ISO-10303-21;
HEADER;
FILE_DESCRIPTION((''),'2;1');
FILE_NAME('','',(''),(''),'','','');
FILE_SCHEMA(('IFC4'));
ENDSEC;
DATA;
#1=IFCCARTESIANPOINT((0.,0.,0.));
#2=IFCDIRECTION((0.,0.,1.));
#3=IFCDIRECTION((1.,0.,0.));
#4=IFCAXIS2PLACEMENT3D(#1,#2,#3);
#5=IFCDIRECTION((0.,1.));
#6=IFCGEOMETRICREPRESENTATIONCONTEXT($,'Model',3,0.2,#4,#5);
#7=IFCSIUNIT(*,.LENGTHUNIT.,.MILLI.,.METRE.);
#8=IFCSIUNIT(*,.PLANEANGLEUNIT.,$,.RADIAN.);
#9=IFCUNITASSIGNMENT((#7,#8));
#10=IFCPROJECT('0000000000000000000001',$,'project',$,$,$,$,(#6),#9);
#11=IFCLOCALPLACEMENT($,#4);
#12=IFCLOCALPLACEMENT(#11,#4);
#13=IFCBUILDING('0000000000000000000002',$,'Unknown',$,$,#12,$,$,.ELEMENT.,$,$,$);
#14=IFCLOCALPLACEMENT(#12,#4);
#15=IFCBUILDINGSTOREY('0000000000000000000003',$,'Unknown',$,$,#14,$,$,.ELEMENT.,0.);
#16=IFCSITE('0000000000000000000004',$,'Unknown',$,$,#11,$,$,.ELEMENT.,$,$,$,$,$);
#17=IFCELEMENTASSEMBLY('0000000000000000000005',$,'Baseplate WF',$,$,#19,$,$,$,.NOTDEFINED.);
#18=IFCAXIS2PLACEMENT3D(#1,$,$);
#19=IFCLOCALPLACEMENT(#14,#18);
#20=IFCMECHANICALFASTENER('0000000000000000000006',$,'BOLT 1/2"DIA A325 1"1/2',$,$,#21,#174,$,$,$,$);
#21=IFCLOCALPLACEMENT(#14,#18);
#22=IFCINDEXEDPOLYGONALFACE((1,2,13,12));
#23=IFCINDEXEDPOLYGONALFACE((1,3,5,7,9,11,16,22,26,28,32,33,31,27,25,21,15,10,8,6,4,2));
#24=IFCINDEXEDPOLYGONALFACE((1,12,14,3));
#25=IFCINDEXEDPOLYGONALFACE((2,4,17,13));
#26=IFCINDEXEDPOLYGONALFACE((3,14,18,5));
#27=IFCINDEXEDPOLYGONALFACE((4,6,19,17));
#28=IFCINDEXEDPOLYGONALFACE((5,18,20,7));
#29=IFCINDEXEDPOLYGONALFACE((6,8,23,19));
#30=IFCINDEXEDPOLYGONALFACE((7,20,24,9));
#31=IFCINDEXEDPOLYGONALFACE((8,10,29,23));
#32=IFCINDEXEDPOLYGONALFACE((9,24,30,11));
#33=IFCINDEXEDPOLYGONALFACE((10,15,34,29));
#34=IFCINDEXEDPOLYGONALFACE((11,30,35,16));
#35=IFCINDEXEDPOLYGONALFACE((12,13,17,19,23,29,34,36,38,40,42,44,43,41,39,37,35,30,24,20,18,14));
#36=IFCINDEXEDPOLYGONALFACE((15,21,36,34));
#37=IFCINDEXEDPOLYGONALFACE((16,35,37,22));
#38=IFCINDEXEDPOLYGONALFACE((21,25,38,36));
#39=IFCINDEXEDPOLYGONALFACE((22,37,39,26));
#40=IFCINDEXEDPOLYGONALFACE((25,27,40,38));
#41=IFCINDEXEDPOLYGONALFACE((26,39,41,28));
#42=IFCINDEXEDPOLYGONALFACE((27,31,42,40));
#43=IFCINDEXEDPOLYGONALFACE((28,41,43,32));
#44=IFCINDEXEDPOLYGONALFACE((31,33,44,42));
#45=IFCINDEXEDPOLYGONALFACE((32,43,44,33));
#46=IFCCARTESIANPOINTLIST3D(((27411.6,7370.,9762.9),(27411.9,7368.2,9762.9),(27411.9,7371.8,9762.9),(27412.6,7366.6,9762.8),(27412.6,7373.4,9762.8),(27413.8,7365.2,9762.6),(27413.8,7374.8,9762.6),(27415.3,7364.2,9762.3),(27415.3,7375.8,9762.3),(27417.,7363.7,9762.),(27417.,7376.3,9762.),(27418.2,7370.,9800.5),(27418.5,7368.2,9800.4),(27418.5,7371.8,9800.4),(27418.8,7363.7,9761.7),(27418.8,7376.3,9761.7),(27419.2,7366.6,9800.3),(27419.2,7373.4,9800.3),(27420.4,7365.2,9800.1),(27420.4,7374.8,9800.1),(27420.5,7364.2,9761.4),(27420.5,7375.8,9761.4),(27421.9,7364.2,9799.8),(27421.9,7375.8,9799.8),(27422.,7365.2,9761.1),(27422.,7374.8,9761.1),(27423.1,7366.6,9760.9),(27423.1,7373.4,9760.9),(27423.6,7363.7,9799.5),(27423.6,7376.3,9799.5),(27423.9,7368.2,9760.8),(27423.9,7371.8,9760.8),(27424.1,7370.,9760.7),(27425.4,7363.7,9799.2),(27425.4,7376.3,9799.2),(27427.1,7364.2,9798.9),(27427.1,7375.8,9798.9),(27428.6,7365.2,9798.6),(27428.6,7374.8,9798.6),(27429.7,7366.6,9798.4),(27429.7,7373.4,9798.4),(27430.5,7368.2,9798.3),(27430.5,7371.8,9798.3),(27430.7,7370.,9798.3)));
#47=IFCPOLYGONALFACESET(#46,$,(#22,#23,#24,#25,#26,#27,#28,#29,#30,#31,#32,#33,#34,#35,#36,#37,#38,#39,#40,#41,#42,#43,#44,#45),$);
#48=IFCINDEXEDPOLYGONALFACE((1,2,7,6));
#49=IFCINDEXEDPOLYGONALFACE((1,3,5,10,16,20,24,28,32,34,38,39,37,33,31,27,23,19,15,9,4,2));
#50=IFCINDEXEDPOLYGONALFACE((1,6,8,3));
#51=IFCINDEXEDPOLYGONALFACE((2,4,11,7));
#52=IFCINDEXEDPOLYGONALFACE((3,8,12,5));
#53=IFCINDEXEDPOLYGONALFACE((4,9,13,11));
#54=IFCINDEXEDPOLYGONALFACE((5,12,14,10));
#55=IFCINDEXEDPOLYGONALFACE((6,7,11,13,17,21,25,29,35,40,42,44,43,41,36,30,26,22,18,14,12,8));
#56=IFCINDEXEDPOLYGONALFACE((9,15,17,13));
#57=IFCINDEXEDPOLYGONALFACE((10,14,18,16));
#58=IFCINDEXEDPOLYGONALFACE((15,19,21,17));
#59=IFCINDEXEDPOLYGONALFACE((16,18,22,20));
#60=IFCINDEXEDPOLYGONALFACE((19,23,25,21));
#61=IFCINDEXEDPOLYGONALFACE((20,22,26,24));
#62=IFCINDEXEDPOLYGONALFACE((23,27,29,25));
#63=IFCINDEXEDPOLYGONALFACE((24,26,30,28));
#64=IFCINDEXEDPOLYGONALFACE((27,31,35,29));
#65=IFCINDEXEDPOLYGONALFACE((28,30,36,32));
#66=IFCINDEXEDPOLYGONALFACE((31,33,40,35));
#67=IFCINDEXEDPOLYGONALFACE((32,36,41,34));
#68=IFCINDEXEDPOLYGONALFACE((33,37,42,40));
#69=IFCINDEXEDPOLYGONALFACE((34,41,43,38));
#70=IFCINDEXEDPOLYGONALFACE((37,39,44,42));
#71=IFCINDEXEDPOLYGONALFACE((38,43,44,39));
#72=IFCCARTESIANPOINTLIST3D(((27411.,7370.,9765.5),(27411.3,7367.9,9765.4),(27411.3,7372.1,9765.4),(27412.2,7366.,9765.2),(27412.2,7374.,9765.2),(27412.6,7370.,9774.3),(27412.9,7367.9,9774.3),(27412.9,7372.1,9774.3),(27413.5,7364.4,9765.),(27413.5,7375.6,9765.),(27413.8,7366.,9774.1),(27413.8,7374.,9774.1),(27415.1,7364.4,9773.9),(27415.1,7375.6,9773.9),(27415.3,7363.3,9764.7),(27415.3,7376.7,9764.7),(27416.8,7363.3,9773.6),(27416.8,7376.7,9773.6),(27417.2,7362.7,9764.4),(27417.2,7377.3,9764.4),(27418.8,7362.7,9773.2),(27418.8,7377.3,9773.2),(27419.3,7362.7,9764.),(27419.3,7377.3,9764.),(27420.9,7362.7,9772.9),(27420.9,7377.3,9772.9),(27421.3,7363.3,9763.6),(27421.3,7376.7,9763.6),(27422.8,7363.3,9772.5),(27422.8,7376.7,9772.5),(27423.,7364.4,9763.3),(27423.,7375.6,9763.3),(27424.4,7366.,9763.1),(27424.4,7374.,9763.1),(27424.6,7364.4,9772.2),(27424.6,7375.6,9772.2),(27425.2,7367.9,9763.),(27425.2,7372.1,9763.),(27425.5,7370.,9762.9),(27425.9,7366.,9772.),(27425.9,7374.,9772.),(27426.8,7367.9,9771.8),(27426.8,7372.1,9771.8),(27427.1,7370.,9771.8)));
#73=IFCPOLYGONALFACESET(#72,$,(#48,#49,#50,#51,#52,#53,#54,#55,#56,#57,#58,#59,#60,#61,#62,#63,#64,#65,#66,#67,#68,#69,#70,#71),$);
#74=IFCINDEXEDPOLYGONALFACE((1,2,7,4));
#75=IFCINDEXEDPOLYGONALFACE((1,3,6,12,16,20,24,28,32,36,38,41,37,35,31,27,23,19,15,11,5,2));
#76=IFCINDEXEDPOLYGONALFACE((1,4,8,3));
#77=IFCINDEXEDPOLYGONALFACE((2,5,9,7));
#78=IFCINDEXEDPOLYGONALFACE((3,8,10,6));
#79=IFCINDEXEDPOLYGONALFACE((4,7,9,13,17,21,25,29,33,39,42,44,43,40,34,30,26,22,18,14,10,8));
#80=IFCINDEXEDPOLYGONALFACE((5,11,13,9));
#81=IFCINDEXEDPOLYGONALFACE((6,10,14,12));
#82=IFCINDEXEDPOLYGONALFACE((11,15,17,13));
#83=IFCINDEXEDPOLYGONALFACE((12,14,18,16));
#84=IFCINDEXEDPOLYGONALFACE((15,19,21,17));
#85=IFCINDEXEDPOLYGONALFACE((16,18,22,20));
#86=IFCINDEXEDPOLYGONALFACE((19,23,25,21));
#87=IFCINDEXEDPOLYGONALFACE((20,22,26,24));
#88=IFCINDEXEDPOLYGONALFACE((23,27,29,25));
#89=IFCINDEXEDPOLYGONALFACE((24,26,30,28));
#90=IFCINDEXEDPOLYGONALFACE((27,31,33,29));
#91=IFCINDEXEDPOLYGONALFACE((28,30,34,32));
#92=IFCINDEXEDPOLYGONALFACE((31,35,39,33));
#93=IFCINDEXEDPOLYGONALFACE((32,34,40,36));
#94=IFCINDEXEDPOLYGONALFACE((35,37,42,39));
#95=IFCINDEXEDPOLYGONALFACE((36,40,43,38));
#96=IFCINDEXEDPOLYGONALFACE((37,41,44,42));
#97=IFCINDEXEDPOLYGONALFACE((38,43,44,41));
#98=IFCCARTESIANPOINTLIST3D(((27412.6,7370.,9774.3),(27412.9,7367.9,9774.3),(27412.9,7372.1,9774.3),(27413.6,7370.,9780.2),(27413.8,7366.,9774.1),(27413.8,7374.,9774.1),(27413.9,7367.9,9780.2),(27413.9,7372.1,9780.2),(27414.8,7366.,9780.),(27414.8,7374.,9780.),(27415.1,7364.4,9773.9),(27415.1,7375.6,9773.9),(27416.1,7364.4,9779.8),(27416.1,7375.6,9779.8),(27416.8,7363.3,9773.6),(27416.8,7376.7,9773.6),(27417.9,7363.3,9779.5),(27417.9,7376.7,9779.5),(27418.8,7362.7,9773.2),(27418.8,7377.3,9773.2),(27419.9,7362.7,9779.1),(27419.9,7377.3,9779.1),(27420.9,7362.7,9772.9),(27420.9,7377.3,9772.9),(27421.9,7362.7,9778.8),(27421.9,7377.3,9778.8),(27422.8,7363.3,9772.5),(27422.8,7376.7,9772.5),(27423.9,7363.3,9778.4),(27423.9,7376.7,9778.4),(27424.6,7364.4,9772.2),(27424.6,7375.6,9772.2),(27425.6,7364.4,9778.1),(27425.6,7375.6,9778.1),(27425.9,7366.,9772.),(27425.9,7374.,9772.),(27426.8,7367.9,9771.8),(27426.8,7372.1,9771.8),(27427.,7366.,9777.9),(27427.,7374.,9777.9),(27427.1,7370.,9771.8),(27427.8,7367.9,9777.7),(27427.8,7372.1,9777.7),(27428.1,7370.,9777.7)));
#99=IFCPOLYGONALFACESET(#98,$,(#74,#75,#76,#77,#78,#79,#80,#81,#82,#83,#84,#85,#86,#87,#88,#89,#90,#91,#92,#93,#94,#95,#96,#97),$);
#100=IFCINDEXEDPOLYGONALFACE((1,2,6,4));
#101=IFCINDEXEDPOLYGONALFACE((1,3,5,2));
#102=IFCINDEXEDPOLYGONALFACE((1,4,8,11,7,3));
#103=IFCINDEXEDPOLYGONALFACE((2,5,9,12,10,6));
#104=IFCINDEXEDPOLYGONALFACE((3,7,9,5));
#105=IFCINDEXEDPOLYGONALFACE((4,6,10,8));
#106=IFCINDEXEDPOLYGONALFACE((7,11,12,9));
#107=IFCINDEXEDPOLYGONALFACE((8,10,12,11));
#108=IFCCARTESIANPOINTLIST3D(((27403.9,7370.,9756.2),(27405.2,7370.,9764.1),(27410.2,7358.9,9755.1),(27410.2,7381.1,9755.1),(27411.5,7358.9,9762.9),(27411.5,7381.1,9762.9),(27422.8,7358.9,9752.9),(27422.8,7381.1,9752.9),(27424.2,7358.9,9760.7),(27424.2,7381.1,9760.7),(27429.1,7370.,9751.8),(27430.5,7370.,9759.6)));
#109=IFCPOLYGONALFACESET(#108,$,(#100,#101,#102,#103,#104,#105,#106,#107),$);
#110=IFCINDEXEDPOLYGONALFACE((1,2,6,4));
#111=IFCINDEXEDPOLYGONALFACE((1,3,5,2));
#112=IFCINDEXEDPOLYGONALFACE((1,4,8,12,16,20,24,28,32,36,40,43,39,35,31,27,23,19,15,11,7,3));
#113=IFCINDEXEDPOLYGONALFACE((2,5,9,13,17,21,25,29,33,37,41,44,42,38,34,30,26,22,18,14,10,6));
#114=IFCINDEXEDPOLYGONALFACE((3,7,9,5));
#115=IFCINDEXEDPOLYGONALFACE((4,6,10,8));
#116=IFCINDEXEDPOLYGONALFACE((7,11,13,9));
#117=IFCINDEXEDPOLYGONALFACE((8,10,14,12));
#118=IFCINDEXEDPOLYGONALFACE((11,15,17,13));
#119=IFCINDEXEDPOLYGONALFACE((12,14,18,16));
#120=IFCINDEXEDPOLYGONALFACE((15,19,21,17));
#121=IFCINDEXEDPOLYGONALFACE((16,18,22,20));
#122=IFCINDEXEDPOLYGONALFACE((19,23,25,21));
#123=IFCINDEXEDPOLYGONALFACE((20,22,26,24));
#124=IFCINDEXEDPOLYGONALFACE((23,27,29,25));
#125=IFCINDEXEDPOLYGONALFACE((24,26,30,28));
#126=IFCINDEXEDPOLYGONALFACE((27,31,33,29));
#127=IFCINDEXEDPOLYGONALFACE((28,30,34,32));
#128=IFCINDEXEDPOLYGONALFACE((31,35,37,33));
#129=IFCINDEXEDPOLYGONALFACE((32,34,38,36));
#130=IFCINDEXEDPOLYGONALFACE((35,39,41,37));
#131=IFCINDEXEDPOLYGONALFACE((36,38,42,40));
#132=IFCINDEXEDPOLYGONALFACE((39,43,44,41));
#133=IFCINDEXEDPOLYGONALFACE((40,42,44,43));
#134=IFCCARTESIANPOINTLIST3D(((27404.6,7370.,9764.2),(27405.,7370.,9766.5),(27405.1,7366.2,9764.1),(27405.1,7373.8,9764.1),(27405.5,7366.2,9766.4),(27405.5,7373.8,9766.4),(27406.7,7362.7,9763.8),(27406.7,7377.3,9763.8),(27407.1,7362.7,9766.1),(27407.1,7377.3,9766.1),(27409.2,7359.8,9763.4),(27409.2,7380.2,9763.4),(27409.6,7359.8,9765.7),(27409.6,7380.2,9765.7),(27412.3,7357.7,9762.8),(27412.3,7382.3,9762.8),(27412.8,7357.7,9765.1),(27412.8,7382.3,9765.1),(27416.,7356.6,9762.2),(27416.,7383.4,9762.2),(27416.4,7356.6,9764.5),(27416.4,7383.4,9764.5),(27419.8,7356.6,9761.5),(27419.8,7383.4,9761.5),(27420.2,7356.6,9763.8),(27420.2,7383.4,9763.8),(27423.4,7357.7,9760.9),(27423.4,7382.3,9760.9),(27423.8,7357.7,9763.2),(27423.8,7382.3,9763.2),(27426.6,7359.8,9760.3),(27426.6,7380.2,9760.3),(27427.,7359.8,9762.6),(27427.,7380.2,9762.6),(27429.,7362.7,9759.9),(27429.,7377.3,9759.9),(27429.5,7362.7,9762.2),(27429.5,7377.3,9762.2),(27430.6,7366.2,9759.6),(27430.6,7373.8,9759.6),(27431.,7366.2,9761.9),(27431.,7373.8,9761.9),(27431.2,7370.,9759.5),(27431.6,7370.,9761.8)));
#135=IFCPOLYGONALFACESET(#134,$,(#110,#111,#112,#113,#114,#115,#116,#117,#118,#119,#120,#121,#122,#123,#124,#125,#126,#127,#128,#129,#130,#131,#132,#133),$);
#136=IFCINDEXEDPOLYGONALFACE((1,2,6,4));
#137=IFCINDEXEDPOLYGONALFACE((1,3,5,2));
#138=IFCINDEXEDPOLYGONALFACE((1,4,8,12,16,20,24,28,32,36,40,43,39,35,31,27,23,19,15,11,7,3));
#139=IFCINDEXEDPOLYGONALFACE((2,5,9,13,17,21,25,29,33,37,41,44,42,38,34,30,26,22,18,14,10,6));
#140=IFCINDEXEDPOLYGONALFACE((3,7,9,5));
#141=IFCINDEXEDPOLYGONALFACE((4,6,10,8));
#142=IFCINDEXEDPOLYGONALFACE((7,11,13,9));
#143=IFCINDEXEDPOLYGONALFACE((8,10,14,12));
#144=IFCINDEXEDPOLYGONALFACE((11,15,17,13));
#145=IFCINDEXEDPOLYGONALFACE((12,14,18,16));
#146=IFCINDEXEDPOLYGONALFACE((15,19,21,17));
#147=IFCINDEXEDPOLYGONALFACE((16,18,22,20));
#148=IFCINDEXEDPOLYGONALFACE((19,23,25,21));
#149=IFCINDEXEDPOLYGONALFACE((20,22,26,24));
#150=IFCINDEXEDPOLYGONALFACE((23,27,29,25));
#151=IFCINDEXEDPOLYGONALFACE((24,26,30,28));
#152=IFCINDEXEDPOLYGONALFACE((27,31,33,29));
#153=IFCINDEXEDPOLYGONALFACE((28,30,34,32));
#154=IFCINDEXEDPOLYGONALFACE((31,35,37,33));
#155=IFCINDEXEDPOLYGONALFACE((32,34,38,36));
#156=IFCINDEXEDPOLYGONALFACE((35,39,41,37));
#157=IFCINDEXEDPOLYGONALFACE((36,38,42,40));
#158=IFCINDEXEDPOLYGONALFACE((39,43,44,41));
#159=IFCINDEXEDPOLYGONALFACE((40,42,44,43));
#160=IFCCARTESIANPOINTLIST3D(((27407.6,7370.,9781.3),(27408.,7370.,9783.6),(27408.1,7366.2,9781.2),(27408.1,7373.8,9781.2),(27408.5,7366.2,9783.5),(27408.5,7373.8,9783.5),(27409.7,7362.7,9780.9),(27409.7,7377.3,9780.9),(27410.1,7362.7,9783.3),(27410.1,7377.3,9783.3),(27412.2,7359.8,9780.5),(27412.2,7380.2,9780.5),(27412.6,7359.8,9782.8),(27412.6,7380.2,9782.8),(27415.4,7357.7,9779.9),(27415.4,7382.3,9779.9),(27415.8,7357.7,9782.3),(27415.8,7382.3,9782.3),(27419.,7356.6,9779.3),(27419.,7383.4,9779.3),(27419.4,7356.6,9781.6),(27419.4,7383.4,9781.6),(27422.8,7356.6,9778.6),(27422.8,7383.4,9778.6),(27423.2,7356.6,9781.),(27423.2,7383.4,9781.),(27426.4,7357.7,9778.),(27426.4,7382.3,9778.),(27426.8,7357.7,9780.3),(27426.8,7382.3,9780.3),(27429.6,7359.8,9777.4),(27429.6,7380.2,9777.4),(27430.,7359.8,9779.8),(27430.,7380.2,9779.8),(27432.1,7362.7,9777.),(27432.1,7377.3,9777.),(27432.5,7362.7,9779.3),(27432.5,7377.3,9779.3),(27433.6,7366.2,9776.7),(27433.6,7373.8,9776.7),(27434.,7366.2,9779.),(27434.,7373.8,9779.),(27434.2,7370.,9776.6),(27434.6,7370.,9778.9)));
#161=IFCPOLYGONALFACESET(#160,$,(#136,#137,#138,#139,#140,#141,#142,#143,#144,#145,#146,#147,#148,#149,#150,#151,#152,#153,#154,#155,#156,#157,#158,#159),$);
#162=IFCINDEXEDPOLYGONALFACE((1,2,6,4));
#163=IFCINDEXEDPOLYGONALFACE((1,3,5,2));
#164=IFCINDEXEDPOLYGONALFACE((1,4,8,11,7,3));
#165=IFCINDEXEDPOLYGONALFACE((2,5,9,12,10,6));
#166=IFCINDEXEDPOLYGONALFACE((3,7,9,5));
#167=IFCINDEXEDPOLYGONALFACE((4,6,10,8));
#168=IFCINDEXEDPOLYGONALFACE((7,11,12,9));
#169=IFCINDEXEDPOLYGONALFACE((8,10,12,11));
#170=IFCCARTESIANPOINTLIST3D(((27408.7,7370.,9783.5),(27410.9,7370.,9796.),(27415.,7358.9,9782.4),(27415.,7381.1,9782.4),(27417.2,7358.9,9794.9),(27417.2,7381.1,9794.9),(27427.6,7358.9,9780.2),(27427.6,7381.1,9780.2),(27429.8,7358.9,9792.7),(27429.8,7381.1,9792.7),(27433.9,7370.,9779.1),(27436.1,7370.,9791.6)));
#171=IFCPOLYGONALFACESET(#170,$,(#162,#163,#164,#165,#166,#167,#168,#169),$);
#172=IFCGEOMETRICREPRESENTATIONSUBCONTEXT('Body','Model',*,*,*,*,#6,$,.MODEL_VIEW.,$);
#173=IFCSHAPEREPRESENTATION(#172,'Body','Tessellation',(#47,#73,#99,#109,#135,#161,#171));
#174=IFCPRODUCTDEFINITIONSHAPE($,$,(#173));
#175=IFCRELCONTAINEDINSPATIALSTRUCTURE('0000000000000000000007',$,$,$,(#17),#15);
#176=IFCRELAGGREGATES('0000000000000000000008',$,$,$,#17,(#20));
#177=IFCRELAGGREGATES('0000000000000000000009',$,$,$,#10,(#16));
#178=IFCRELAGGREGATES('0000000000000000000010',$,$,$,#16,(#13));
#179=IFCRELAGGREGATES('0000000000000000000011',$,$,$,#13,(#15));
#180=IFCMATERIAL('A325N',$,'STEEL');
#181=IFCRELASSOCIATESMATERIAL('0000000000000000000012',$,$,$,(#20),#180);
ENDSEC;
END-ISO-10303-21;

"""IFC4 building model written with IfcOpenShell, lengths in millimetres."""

from ifc_helpers import new_model, si_unit, direction, frame, origin_with_axes, place, context, subcontext, project, spatial, line, arc, indexed_curve, outline, extrude, source, transform, mapped, material, element, aggregate, save


model = new_model("IFC4")

# Units and contexts
model_context = context("Model", 3, precision=0.2, world=origin_with_axes(), true_north=direction((0.0, 1.0)))
body_context = subcontext(model_context, "Body", "Model", "MODEL_VIEW")
ifc_project = project(units=[si_unit("LENGTHUNIT", "METRE", prefix="MILLI"), si_unit("PLANEANGLEUNIT", "RADIAN")], contexts=[model_context])

# Site, building, storey
site_placement = place(None, origin_with_axes())
site = spatial("IfcSite", under=ifc_project, at=site_placement, Name="Unknown", CompositionType="ELEMENT")
building_placement = place(site_placement, origin_with_axes())
building = spatial("IfcBuilding", under=site, at=building_placement, Name="Unknown", CompositionType="ELEMENT")
storey_placement = place(building_placement, origin_with_axes())
storey = spatial("IfcBuildingStorey", under=building, at=storey_placement, Name="Unknown", CompositionType="ELEMENT", Elevation=0.0)

# Shared definitions
ifc_material_1 = material(Name="A325N", Category="STEEL")
shared_shape_1 = source(origin_with_axes(), body_context, "Body", "SweptSolid", [
    extrude(outline(indexed_curve([(6.3, 0.0), (0.0, 6.3), (-6.3, 0.0), (0.0, -6.3)], segments=[arc(1, 2, 3), arc(3, 4, 1)])), frame((0.0, 0.0, 17.4), z_axis=(0.0, 0.0, -1.0), x_axis=(0.0, 1.0, 0.0)), (0.0, 0.0, 1.0), 38.1),
    extrude(outline(indexed_curve([(7.3, 0.0), (0.0, 7.3), (-7.3, 0.0), (0.0, -7.3)], segments=[arc(1, 2, 3), arc(3, 4, 1)])), frame((0.0, 0.0, 15.0), z_axis=(0.0, 0.0, -1.0), x_axis=(0.0, 1.0, 0.0)), (0.0, 0.0, 1.0), 9.0),
    extrude(outline(indexed_curve([(7.3, 0.0), (0.0, 7.3), (-7.3, 0.0), (0.0, -7.3)], segments=[arc(1, 2, 3), arc(3, 4, 1)])), frame((0.0, 0.0, 6.0), z_axis=(0.0, 0.0, -1.0), x_axis=(0.0, 1.0, 0.0)), (0.0, 0.0, 1.0), 6.0),
    extrude(outline(indexed_curve([(12.8, 0.0), (6.4, 11.1), (-6.4, 11.1), (-12.8, 0.0), (-6.4, -11.1), (6.4, -11.1)], segments=[line(1, 2, 3, 4, 5, 6, 1)])), frame((0.0, 0.0, 25.3), z_axis=(0.0, 0.0, -1.0), x_axis=(0.0, 1.0, 0.0)), (0.0, 0.0, 1.0), 7.9),
    extrude(outline(indexed_curve([(13.5, 0.0), (0.0, 13.5), (-13.5, 0.0), (0.0, -13.5)], segments=[arc(1, 2, 3), arc(3, 4, 1)])), frame((0.0, 0.0, 17.4), z_axis=(0.0, 0.0, -1.0), x_axis=(0.0, 1.0, 0.0)), (0.0, 0.0, 1.0), 2.4),
    extrude(outline(indexed_curve([(13.5, 0.0), (0.0, 13.5), (-13.5, 0.0), (0.0, -13.5)], segments=[arc(1, 2, 3), arc(3, 4, 1)])), frame((0.0, 0.0, 0.0), z_axis=(0.0, 0.0, -1.0), x_axis=(0.0, 1.0, 0.0)), (0.0, 0.0, 1.0), 2.4),
    extrude(outline(indexed_curve([(12.8, 0.0), (6.4, 11.1), (-6.4, 11.1), (-12.8, 0.0), (-6.4, -11.1), (6.4, -11.1)], segments=[line(1, 2, 3, 4, 5, 6, 1)])), frame((0.0, 0.0, -2.4), z_axis=(0.0, 0.0, -1.0), x_axis=(0.0, 1.0, 0.0)), (0.0, 0.0, 1.0), 12.7),
])

# Element assembly, mechanical fastener
assembly_1_placement = place(storey_placement, frame((27449.9, 7400.0, 9770.8), z_axis=(-0.173648, 0.0, -0.984808), x_axis=(0.0, -1.0, 0.0)))
assembly_1 = element("IfcElementAssembly", 1, at=assembly_1_placement, inside=storey, Name="Baseplate WF", PredefinedType="NOTDEFINED")
mechanical_fastener_1_placement = place(assembly_1_placement, frame((30.0, 30.0, -3.0), z_axis=(0.0, 0.0, 1.0), x_axis=(1.0, 0.0, 0.0)))
mechanical_fastener_1 = element("IfcMechanicalFastener", 2, at=mechanical_fastener_1_placement, material=ifc_material_1, Name="BOLT 1/2\"DIA A325 1\"1/2", context=body_context, shape_type="MappedRepresentation", body=[
    mapped(shared_shape_1, transform((0.0, 0.0, 0.0))),
])
aggregate(assembly_1, [mechanical_fastener_1])

save(model, "model.ifc")
